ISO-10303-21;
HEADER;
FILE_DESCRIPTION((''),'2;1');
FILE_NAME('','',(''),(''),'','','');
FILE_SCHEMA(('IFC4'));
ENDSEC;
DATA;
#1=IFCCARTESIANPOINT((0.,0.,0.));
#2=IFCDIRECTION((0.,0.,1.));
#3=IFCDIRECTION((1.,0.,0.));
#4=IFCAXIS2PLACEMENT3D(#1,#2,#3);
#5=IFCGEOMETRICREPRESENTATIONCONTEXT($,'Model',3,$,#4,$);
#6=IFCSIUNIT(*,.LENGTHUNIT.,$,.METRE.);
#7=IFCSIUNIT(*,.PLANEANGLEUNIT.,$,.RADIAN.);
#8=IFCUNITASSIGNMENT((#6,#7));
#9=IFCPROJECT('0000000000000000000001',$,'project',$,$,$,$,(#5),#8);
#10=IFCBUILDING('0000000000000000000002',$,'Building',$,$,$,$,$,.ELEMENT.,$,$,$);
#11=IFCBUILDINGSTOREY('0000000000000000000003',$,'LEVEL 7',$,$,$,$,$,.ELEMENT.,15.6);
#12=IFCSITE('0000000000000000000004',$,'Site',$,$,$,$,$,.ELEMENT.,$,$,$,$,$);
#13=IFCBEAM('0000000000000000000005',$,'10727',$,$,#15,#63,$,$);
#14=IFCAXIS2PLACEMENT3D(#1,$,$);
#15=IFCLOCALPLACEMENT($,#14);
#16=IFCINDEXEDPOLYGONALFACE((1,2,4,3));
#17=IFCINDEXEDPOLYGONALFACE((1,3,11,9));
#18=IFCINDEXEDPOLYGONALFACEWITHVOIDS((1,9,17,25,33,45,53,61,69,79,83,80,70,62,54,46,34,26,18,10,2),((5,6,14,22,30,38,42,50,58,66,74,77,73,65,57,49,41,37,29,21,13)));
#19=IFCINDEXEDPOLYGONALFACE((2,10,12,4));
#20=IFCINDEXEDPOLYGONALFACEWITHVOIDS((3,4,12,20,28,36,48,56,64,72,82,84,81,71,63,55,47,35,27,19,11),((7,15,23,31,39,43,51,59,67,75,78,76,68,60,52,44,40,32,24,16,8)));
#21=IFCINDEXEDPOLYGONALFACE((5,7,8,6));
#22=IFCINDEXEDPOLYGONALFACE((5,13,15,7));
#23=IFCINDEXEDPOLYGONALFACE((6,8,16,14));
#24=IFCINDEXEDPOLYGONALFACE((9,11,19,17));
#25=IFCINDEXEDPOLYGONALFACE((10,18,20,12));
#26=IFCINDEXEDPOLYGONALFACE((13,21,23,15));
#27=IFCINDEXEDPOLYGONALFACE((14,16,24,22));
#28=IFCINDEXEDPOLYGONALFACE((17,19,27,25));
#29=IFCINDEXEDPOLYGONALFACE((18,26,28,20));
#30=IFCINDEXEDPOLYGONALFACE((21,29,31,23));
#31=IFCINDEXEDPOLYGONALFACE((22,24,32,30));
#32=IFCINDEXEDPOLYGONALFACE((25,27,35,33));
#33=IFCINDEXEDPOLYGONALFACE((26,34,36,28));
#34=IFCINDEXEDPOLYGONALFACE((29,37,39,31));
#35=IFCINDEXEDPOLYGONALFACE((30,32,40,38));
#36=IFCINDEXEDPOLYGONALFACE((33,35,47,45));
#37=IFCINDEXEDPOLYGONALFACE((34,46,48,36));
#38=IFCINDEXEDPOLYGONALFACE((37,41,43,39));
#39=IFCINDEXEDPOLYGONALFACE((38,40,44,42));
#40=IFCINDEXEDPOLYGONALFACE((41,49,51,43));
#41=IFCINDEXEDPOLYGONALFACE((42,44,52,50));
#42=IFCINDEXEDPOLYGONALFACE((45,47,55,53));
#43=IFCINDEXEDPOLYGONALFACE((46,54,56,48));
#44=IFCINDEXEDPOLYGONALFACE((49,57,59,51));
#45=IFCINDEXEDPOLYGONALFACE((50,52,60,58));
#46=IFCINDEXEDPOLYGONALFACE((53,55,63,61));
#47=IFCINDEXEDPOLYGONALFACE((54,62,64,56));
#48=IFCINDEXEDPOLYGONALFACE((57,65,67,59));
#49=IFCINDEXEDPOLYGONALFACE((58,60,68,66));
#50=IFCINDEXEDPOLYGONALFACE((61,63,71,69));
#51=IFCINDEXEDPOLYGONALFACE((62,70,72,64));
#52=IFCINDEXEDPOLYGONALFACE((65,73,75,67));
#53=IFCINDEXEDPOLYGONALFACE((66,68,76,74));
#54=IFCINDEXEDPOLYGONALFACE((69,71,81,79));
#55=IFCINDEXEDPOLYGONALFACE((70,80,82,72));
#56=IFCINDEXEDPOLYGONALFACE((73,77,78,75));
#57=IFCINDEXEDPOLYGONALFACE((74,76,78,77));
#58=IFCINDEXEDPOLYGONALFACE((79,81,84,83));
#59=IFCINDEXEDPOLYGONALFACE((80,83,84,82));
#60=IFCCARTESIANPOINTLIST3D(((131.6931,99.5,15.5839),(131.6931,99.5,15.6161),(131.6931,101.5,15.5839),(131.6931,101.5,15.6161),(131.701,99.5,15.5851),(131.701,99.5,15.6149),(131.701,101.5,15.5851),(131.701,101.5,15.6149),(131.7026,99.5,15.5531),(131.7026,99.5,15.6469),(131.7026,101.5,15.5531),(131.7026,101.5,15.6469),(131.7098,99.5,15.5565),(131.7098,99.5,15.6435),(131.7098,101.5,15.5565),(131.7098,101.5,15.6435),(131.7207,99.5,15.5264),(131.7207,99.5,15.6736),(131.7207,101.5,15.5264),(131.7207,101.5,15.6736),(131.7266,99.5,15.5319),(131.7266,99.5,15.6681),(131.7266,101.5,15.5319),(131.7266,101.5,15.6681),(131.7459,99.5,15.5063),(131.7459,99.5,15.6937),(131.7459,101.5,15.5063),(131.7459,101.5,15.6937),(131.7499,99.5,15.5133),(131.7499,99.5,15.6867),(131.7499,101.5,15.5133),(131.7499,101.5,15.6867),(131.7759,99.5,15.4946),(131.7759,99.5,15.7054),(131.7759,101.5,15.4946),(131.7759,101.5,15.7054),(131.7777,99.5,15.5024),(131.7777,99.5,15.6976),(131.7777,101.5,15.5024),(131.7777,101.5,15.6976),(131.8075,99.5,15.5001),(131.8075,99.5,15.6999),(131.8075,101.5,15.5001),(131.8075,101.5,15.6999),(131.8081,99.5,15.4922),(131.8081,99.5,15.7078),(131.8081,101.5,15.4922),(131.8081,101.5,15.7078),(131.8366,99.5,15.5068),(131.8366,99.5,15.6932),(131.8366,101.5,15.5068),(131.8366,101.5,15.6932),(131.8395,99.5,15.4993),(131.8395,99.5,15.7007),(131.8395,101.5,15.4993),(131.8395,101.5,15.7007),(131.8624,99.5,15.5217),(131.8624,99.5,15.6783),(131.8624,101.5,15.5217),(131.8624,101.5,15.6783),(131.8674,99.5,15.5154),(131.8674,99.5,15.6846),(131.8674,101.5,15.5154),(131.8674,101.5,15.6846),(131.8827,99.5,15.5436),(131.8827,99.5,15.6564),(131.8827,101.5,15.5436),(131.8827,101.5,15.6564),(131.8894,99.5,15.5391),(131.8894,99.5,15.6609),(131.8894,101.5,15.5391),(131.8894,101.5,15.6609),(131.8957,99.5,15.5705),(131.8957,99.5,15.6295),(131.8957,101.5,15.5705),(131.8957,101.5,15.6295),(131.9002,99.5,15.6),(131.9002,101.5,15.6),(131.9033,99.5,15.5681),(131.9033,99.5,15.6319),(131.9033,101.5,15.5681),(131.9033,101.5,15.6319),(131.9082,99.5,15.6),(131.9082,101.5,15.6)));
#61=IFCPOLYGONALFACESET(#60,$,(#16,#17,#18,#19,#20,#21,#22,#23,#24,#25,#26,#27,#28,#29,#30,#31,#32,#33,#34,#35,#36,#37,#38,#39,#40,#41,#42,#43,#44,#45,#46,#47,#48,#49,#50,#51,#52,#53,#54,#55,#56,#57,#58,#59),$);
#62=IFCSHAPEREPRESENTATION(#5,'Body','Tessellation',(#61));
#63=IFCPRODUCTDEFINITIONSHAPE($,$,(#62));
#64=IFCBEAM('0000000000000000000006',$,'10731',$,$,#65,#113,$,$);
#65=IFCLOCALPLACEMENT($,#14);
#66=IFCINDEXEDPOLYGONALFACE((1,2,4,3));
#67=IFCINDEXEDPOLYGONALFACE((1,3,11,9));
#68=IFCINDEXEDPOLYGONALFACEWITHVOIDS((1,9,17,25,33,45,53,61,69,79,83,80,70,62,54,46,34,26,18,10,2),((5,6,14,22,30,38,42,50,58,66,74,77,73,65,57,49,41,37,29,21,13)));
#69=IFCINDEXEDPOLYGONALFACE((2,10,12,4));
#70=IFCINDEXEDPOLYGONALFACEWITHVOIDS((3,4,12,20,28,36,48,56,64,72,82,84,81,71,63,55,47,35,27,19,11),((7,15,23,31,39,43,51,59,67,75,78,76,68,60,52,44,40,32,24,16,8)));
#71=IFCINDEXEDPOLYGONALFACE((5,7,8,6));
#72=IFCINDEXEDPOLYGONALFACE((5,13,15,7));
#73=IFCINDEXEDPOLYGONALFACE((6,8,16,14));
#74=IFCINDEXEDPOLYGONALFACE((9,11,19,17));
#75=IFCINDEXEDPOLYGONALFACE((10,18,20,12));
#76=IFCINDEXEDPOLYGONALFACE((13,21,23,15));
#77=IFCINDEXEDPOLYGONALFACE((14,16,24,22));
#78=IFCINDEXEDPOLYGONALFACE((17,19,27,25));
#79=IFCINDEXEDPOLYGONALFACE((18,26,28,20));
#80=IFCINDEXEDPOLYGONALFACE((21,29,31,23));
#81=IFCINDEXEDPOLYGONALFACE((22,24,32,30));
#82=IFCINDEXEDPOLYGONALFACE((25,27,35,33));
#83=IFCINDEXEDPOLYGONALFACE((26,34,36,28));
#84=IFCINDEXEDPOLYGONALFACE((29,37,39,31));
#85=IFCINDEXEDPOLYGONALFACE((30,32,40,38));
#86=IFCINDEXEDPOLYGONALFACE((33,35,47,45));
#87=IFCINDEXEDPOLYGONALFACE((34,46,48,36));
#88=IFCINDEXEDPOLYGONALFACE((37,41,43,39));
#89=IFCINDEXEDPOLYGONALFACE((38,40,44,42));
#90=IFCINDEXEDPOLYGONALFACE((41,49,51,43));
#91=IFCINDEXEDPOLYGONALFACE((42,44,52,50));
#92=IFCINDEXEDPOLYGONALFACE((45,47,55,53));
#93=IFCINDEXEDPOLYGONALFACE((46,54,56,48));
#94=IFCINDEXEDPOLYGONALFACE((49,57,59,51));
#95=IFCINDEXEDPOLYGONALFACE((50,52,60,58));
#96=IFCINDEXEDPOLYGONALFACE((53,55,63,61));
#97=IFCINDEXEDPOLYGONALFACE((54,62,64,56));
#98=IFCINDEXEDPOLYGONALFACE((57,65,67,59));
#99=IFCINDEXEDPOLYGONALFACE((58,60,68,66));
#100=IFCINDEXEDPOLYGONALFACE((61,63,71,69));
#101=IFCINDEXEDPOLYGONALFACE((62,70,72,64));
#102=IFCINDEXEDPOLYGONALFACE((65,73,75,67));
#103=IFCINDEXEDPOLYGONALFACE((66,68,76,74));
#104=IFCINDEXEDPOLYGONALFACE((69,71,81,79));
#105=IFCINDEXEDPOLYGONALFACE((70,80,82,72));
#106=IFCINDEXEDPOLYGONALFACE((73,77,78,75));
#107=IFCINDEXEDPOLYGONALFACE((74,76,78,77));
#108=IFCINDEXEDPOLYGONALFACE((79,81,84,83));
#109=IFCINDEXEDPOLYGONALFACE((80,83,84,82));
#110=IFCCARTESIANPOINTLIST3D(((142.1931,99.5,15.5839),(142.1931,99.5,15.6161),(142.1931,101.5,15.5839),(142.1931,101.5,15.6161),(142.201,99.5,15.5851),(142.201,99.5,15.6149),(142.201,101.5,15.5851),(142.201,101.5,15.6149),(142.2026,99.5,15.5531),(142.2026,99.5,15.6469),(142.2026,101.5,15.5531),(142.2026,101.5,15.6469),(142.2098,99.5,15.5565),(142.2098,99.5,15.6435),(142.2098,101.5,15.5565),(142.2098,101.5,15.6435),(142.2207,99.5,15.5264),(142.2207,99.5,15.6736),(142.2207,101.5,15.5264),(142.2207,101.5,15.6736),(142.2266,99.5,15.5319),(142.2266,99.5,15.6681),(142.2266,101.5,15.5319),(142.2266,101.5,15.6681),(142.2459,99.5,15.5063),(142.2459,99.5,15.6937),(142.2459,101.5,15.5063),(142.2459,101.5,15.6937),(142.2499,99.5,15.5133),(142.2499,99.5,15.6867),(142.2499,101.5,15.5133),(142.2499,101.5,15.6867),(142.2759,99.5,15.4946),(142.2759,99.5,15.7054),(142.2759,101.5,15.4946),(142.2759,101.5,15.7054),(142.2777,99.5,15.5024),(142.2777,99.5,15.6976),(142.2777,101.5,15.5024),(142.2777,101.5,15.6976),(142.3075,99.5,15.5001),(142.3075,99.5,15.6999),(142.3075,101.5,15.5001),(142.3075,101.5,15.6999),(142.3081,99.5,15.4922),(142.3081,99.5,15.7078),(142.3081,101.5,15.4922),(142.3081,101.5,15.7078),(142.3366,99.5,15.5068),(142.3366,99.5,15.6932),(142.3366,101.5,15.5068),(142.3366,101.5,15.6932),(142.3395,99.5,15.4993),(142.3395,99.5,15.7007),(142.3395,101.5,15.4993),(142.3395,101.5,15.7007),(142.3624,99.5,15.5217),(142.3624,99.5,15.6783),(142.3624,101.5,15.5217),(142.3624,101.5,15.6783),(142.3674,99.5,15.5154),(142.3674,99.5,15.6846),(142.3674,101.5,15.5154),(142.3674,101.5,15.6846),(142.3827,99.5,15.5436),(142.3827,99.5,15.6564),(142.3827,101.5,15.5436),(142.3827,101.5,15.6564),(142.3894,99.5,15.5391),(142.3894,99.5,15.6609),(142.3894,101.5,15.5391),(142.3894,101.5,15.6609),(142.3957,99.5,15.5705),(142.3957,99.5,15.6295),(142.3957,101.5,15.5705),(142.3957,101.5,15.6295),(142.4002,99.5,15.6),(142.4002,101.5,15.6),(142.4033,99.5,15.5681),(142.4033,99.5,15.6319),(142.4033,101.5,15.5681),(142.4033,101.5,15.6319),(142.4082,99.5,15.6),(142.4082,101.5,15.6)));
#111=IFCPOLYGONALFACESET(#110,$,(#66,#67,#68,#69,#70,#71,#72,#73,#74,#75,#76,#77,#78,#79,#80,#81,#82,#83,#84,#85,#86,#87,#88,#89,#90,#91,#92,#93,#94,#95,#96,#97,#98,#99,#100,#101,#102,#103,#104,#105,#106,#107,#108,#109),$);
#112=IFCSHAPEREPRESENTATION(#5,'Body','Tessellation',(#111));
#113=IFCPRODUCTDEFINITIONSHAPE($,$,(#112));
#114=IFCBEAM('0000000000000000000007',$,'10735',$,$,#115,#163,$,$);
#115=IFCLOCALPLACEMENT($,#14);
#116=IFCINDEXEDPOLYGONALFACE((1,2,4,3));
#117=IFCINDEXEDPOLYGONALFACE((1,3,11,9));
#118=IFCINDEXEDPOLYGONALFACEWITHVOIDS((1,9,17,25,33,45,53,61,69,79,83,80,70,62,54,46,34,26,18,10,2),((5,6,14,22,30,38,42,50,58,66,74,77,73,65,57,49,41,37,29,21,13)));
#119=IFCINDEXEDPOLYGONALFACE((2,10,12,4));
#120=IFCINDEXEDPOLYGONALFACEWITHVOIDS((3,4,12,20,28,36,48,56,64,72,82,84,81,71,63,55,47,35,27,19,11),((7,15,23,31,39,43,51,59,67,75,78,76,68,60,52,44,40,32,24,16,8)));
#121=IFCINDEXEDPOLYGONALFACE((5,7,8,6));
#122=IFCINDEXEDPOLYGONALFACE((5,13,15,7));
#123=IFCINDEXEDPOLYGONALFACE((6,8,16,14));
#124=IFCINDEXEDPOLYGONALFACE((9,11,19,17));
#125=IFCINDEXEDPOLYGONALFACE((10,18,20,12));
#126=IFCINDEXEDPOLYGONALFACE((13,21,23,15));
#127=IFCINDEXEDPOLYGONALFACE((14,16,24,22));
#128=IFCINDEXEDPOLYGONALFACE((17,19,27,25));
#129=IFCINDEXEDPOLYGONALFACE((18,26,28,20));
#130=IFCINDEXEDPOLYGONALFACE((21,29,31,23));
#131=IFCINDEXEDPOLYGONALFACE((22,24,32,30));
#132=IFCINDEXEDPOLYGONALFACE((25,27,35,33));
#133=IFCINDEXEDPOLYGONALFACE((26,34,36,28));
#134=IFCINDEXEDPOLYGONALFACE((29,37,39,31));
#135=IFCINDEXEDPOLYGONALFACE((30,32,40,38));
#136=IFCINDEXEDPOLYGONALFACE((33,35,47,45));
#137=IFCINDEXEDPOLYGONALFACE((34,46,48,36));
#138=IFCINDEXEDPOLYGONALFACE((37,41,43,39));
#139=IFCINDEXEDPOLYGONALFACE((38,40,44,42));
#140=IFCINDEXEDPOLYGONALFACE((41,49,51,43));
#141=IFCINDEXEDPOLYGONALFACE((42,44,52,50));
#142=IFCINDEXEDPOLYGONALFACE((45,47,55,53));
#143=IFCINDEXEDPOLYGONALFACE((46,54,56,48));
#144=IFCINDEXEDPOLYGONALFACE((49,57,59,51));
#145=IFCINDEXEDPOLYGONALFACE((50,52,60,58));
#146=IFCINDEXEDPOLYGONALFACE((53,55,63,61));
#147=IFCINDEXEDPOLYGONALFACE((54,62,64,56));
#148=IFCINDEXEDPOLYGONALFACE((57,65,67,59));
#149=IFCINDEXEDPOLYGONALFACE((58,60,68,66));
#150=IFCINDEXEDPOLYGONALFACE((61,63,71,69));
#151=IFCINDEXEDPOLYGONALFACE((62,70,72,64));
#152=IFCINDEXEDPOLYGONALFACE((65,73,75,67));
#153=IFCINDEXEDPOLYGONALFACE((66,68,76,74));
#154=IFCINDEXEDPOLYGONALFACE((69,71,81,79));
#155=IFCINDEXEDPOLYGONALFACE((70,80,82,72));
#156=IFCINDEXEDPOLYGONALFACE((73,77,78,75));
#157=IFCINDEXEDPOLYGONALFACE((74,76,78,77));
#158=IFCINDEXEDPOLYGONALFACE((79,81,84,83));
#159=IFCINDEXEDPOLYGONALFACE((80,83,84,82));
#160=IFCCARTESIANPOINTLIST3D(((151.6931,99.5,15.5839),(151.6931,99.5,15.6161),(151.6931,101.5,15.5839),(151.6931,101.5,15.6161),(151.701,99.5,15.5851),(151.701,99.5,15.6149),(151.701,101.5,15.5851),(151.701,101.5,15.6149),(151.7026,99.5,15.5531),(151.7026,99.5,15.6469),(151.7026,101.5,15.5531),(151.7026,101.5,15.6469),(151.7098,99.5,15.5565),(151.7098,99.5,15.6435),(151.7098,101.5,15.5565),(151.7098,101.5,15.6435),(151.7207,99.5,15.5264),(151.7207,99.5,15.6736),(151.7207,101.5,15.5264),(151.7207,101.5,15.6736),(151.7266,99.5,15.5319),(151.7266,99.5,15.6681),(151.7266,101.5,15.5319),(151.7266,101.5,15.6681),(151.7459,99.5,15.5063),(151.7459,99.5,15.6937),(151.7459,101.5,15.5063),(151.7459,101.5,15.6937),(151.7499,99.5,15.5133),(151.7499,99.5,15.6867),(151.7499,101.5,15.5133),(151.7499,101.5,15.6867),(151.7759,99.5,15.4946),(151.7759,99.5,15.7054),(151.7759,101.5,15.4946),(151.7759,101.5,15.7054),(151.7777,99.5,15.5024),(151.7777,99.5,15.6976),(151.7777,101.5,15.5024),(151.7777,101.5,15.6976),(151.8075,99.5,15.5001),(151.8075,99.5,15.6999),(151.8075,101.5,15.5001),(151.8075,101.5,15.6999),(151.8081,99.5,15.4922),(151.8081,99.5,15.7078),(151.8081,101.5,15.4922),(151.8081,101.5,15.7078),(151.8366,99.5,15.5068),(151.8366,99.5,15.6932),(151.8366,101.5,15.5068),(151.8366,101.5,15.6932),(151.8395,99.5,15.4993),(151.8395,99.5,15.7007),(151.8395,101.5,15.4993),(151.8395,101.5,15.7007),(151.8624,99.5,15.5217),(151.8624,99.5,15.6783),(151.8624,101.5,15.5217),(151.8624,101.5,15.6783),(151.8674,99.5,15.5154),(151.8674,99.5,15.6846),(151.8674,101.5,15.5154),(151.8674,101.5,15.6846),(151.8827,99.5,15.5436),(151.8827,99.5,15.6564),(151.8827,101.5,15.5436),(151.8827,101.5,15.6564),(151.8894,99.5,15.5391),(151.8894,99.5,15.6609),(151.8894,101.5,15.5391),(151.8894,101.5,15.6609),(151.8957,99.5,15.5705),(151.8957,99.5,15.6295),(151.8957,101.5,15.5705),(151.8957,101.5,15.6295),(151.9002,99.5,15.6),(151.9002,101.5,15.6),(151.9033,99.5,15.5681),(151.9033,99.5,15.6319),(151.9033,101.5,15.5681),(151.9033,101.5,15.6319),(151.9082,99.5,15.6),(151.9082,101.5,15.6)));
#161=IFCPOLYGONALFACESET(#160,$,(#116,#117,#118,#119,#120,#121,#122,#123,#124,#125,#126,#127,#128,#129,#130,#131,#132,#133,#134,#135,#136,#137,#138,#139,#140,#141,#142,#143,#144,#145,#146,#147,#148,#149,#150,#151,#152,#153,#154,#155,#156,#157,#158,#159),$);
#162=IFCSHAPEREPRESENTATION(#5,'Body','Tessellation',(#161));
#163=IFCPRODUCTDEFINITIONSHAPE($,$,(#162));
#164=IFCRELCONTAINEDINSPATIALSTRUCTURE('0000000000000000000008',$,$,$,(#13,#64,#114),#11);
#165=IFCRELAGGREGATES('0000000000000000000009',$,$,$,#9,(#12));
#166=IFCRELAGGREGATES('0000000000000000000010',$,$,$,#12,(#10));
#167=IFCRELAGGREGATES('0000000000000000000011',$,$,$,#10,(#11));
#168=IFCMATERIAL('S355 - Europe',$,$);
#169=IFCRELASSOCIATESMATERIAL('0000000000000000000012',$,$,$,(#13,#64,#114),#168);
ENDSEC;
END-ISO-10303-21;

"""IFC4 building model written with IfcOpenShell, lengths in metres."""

from ifc_helpers import new_model, si_unit, frame, origin_with_axes, origin_2d_with_axis, place, context, project, spatial, hollow_circle, extrude, material, material_profile, profile_set, profile_usage, element, save


model = new_model("IFC4")

# Units and contexts
model_context = context("Model", 3, world=origin_with_axes())
ifc_project = project(units=[si_unit("LENGTHUNIT", "METRE"), si_unit("PLANEANGLEUNIT", "RADIAN")], contexts=[model_context])

# Site, building, storey
site = spatial("IfcSite", under=ifc_project, Name="Site", CompositionType="ELEMENT")
building = spatial("IfcBuilding", under=site, Name="Building", CompositionType="ELEMENT")
storey = spatial("IfcBuildingStorey", under=building, Name="LEVEL 7", CompositionType="ELEMENT", Elevation=15.6)

# Shared definitions
ifc_material = material(Name="S355 - Europe")

# Beams
ifc_material_profile_1 = material_profile(ifc_material, hollow_circle(Radius=0.1081, WallThickness=0.008, at=origin_2d_with_axis()))
ifc_profile_set_1 = profile_set([ifc_material_profile_1])
ifc_profile_usage_1 = profile_usage(ifc_profile_set_1, cardinal=10)
beam_1_placement = place(None, frame((131.8, 101.5, 15.6), z_axis=(0.0, -1.0, 0.0), x_axis=(1.0, 0.0, 0.0)))
element("IfcBeam", 1, at=beam_1_placement, inside=storey, material=ifc_profile_usage_1, Name="10727", context=model_context, shape_type="SweptSolid", body=[
    extrude(hollow_circle(Radius=0.1081, WallThickness=0.008, at=origin_2d_with_axis()), origin_with_axes(), (0.0, 0.0, 1.0), 2.0),
])
ifc_material_profile_2 = material_profile(ifc_material, hollow_circle(Radius=0.1081, WallThickness=0.008, at=origin_2d_with_axis()))
ifc_profile_set_2 = profile_set([ifc_material_profile_2])
ifc_profile_usage_2 = profile_usage(ifc_profile_set_2, cardinal=10)
beam_2_placement = place(None, frame((142.3, 101.5, 15.6), z_axis=(0.0, -1.0, 0.0), x_axis=(1.0, 0.0, 0.0)))
element("IfcBeam", 2, at=beam_2_placement, inside=storey, material=ifc_profile_usage_2, Name="10731", context=model_context, shape_type="SweptSolid", body=[
    extrude(hollow_circle(Radius=0.1081, WallThickness=0.008, at=origin_2d_with_axis()), origin_with_axes(), (0.0, 0.0, 1.0), 2.0),
])
ifc_material_profile_3 = material_profile(ifc_material, hollow_circle(Radius=0.1081, WallThickness=0.008, at=origin_2d_with_axis()))
ifc_profile_set_3 = profile_set([ifc_material_profile_3])
ifc_profile_usage_3 = profile_usage(ifc_profile_set_3, cardinal=10)
beam_3_placement = place(None, frame((151.8, 101.5, 15.6), z_axis=(0.0, -1.0, 0.0), x_axis=(1.0, 0.0, 0.0)))
element("IfcBeam", 3, at=beam_3_placement, inside=storey, material=ifc_profile_usage_3, Name="10735", context=model_context, shape_type="SweptSolid", body=[
    extrude(hollow_circle(Radius=0.1081, WallThickness=0.008, at=origin_2d_with_axis()), origin_with_axes(), (0.0, 0.0, 1.0), 2.0),
])

save(model, "model.ifc")
